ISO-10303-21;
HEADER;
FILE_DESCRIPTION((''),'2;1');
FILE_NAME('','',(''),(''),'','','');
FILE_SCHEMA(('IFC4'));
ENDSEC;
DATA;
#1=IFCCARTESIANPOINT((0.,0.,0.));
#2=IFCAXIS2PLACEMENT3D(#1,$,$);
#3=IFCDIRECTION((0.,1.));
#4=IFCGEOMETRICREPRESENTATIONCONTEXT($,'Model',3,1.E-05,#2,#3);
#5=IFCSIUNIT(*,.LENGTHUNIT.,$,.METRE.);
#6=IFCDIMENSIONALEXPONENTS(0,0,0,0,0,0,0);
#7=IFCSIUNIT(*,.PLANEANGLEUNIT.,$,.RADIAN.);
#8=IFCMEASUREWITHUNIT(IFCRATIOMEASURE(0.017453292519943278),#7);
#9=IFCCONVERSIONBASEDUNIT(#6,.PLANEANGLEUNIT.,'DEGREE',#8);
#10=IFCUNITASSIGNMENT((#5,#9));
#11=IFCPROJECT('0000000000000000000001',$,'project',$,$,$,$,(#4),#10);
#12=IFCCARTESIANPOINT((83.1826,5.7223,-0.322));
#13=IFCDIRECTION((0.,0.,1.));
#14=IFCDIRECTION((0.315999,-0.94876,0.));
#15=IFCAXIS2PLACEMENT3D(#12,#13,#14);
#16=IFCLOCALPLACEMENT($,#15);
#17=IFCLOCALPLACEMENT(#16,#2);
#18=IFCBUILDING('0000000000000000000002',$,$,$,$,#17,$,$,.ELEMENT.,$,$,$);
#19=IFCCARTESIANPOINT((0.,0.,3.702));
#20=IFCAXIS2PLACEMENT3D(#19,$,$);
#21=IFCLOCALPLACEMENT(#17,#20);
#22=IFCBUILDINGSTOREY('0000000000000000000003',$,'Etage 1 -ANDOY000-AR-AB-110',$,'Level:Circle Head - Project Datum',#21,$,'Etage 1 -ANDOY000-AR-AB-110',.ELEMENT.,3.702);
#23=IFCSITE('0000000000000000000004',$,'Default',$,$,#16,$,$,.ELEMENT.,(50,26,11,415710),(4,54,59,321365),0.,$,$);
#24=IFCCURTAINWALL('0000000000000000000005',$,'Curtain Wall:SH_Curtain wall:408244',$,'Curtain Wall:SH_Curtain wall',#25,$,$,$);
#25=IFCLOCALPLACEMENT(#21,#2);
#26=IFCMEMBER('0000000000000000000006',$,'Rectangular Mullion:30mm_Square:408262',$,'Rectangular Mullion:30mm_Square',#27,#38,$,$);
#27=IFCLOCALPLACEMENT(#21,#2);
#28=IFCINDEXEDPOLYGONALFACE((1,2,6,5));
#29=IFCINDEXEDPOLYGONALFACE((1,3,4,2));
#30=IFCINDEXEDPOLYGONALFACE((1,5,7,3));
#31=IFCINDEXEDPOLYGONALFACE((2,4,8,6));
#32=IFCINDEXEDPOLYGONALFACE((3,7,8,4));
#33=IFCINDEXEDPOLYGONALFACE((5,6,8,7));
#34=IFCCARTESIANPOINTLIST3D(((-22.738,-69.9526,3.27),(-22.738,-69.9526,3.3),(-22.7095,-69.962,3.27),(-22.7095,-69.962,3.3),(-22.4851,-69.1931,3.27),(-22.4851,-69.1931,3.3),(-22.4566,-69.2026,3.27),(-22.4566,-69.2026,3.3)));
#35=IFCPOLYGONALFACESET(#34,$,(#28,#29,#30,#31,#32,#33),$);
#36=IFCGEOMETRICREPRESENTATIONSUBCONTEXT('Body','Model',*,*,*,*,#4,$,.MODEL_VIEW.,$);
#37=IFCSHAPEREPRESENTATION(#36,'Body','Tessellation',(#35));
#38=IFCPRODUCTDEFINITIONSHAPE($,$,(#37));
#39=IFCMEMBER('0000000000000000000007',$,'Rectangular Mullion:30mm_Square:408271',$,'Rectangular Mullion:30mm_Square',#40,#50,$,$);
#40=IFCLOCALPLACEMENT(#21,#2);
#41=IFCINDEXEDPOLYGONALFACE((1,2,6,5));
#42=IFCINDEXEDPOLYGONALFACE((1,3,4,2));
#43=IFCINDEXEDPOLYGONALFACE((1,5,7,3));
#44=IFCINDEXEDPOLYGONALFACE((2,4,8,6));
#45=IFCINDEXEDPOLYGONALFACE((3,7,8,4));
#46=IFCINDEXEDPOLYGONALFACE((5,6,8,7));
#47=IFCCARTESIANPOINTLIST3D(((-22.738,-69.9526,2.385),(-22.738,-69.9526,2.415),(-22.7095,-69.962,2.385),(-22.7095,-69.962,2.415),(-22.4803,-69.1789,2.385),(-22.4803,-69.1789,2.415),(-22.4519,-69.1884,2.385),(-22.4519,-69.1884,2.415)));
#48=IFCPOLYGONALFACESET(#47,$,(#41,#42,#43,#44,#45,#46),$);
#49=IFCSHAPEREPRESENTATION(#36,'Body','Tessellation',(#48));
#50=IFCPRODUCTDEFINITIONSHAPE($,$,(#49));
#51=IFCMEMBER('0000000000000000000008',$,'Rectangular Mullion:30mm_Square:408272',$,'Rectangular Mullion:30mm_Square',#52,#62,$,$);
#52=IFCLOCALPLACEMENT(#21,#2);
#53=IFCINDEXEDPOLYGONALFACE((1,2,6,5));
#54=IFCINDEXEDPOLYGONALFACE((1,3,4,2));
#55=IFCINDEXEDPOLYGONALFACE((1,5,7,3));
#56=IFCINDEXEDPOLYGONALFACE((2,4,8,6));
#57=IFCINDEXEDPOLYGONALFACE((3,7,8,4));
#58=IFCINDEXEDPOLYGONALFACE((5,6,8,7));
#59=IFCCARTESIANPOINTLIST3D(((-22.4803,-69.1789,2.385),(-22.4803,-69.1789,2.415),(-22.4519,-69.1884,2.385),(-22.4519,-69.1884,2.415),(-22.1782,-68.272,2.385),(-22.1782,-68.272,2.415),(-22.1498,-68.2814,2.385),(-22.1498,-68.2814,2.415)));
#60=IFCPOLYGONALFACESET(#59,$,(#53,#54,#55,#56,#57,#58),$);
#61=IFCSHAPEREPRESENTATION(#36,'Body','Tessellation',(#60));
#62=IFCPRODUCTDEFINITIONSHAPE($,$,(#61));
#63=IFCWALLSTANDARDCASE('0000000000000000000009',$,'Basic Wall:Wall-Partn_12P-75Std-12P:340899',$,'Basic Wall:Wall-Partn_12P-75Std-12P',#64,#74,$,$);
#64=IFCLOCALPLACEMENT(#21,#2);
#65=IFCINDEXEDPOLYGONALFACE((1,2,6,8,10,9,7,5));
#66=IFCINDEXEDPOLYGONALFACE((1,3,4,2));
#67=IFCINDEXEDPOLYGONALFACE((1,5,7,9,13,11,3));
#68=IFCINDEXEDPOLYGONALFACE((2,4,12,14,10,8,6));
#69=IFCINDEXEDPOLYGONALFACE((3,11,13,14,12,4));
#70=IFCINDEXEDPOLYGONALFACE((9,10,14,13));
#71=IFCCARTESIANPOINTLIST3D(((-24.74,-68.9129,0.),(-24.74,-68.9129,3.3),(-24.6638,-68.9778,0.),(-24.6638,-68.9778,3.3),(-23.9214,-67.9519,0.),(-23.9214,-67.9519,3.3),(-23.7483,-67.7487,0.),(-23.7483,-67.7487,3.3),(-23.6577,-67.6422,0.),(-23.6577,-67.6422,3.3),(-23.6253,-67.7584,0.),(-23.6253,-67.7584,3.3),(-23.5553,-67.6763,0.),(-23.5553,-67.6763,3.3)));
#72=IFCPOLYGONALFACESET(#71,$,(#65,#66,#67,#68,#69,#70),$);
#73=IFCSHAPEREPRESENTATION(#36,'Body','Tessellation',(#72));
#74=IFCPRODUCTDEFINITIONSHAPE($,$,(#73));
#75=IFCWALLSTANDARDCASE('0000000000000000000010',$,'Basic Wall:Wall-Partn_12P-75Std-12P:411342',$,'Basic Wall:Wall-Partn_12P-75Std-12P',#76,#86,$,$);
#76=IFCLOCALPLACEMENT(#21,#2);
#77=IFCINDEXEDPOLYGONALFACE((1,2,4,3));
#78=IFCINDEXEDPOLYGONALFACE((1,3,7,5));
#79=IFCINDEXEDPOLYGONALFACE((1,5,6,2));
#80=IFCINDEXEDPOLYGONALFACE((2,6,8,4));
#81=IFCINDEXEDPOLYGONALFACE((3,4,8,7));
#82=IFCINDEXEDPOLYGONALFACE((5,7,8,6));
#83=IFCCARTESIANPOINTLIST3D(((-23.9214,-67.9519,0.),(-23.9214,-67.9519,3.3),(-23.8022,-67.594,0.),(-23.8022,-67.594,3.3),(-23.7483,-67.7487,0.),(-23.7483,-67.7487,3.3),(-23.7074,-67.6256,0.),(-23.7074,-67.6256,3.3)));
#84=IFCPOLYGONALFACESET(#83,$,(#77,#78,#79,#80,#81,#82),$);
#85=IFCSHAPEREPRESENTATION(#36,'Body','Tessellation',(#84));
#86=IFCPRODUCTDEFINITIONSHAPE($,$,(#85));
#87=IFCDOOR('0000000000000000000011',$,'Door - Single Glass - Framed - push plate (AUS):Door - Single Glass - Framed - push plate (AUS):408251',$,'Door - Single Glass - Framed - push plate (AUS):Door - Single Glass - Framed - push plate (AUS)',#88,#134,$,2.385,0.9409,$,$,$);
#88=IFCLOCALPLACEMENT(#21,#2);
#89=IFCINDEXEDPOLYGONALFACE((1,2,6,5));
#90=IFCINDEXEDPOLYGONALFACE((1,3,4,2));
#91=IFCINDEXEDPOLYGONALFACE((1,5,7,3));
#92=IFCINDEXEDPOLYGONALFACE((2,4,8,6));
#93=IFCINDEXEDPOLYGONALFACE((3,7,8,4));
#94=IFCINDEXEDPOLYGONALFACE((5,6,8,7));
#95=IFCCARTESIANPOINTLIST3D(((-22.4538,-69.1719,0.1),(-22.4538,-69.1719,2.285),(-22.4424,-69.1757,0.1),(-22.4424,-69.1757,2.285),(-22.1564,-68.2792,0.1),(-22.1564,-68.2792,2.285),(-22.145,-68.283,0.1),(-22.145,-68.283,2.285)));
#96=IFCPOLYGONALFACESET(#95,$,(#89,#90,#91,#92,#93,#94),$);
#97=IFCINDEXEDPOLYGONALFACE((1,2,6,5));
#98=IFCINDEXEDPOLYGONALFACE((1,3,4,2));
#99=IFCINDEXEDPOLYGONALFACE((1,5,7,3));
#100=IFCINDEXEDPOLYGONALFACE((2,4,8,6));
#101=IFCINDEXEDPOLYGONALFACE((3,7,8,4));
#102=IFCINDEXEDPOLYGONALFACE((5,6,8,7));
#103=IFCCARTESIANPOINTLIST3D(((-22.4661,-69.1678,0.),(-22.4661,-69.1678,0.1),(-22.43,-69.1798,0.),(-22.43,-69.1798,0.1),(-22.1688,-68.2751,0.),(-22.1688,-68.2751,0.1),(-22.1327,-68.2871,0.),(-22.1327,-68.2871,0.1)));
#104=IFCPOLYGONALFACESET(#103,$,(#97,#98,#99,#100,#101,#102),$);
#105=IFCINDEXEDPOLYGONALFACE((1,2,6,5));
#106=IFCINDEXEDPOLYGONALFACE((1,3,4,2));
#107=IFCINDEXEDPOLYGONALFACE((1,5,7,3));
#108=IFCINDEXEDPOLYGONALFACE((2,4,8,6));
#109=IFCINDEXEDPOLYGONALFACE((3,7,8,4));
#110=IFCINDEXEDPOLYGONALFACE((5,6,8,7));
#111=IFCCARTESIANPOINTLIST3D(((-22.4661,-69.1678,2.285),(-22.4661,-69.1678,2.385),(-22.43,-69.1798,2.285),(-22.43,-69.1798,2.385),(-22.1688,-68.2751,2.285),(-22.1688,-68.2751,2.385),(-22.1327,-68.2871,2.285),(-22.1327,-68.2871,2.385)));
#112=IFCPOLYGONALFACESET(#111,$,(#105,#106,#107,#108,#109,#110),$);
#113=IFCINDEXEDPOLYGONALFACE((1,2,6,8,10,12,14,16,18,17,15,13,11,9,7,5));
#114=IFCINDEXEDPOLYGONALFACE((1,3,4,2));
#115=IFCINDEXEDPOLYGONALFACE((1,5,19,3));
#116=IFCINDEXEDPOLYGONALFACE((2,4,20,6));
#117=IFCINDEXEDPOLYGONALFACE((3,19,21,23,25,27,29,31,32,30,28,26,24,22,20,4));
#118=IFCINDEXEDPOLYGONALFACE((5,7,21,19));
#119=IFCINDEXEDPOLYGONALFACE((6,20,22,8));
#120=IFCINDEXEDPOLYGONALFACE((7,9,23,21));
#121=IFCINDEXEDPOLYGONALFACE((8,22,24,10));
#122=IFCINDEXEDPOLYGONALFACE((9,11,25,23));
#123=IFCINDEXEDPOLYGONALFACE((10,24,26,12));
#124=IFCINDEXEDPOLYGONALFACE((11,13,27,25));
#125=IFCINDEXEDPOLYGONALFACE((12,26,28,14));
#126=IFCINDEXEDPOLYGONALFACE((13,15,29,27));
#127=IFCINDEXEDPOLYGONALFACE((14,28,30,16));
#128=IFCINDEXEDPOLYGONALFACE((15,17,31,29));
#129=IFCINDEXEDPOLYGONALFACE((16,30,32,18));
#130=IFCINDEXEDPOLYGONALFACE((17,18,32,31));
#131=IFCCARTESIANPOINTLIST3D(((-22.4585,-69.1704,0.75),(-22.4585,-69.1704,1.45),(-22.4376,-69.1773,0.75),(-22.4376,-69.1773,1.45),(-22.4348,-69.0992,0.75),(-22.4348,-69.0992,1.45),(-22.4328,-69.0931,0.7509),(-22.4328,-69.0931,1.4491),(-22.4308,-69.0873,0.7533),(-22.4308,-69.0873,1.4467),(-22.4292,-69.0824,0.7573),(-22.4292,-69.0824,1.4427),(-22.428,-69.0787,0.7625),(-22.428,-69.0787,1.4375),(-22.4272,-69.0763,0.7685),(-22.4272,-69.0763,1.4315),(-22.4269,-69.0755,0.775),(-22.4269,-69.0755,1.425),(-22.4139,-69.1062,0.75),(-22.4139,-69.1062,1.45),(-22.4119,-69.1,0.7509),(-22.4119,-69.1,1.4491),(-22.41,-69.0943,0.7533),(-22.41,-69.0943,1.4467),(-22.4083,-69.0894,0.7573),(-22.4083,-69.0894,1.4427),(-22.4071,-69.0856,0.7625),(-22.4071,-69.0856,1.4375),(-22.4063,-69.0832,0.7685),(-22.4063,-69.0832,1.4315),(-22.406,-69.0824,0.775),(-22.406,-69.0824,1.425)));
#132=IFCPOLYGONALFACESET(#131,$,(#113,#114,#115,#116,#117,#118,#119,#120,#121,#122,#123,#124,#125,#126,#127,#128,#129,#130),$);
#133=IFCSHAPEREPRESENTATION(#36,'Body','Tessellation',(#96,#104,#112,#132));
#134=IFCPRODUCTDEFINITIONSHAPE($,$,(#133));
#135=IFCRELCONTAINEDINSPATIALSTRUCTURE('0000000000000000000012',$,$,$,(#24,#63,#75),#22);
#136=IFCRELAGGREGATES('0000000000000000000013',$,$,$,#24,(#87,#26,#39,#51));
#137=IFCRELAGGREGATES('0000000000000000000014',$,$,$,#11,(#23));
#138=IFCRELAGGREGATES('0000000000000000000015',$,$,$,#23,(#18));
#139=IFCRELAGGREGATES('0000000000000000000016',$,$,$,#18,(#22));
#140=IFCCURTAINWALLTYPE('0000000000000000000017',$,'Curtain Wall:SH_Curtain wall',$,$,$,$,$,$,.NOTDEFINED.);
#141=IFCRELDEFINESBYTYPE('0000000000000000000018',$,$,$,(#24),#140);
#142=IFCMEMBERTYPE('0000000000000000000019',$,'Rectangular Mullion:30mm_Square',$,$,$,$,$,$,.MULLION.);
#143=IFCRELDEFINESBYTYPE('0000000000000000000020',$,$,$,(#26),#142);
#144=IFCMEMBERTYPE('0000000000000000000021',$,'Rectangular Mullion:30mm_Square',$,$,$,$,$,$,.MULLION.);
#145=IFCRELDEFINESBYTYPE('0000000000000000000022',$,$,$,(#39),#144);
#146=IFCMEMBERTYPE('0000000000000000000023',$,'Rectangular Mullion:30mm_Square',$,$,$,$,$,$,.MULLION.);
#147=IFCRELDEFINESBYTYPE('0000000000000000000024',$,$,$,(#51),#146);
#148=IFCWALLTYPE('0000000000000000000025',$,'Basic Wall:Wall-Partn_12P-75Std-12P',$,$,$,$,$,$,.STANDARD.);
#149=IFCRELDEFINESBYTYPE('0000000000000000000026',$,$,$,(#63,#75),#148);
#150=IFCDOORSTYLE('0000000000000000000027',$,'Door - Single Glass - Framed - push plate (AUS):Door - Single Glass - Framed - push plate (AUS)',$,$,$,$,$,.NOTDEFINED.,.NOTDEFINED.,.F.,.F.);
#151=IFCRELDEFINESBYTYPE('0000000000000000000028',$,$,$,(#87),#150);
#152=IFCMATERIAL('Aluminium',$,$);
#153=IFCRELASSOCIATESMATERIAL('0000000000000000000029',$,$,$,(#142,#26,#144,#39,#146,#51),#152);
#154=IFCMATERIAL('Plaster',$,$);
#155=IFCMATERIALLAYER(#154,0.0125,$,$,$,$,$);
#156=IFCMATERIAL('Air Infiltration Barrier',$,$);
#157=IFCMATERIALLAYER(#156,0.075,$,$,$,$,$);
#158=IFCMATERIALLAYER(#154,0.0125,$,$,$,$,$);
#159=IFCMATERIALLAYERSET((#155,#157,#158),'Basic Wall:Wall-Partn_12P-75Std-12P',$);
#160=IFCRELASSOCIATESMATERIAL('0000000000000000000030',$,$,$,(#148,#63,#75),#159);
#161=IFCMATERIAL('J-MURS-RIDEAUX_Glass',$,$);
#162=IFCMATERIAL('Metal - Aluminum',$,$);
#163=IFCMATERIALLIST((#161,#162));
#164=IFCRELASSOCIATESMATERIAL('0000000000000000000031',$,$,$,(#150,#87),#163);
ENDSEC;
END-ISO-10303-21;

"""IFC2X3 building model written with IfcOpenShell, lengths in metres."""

from ifc_helpers import new_model, entity, si_unit, converted_unit, direction, frame, frame_2d, origin, origin_2d_with_axis, place, context, subcontext, project, spatial, polyline, circle_curve, parameter, trimmed, segment, composite_curve, rectangle, outline, extrude, source, transform, mapped, material, material_list, layer, layer_set, layer_usage, type_object, type_shapes, element, aggregate, save


model = new_model("IFC2X3")

# Units and contexts
model_context = context("Model", 3, precision=1e-05, world=origin(), true_north=direction((0.0, 1.0)))
body_context = subcontext(model_context, "Body", "Model", "MODEL_VIEW")
ifc_project = project(units=[si_unit("LENGTHUNIT", "METRE"), converted_unit("PLANEANGLEUNIT", "DEGREE", entity("IfcRatioMeasure", 0.017453292519943278), si_unit("PLANEANGLEUNIT", "RADIAN"), dimensions=[0, 0, 0, 0, 0, 0, 0])], contexts=[model_context])

# Site, building, storey
site_placement = place(None, frame((83.1826, 5.7223, -0.322), z_axis=(0.0, 0.0, 1.0), x_axis=(0.315999, -0.94876, 0.0)))
site = spatial("IfcSite", under=ifc_project, at=site_placement, Name="Default", CompositionType="ELEMENT", RefLatitude=(50, 26, 11, 415710), RefLongitude=(4, 54, 59, 321365), RefElevation=0.0)
building_placement = place(site_placement, origin())
building = spatial("IfcBuilding", under=site, at=building_placement, CompositionType="ELEMENT")
storey_placement = place(building_placement, frame((0.0, 0.0, 3.702)))
storey = spatial("IfcBuildingStorey", under=building, at=storey_placement, Name="Etage 1 -ANDOY000-AR-AB-110", ObjectType="Level:Circle Head - Project Datum", LongName="Etage 1 -ANDOY000-AR-AB-110", CompositionType="ELEMENT", Elevation=3.702)

# Shared definitions
curtain_wall_type_1 = type_object("IfcCurtainWallType", Name="Curtain Wall:SH_Curtain wall", PredefinedType="NOTDEFINED")
ifc_material_1 = material(Name="Aluminium")

# Curtain wall
curtain_wall_1_placement = place(storey_placement, frame((0.0, 0.0, -3.702)))
curtain_wall_1 = element("IfcCurtainWall", 1, at=curtain_wall_1_placement, inside=storey, type_object=curtain_wall_type_1, Name="Curtain Wall:SH_Curtain wall:408244", ObjectType="Curtain Wall:SH_Curtain wall")

# Members
member_type_1 = type_object("IfcMemberType", Name="Rectangular Mullion:30mm_Square", PredefinedType="MULLION", material=ifc_material_1)
shared_shape_1 = source(origin(), body_context, "Body", "SweptSolid", [
    extrude(rectangle(XDim=0.03, YDim=0.03, at=frame_2d((0.0, 0.0), x_axis=(1.0, 0.0))), frame((-0.015, 0.0, -0.8005), z_axis=(0.0, 0.0, 1.0), x_axis=(0.0, -1.0, 0.0)), (0.0, 0.0, 1.0), 0.8005),
])
type_shapes(member_type_1, [shared_shape_1])
member_1_placement = place(curtain_wall_1_placement, frame((-22.4708, -69.1979, 7.002), z_axis=(0.316, 0.948759, 0.0), x_axis=(0.0, 0.0, 1.0)))
member_1 = element("IfcMember", 2, at=member_1_placement, type_object=member_type_1, material=ifc_material_1, Name="Rectangular Mullion:30mm_Square:408262", ObjectType="Rectangular Mullion:30mm_Square", context=body_context, shape_type="MappedRepresentation", body=[
    mapped(shared_shape_1, transform((0.0, 0.0, 0.0), scale=1.0)),
])
member_type_2 = type_object("IfcMemberType", Name="Rectangular Mullion:30mm_Square", PredefinedType="MULLION", material=ifc_material_1)
shared_shape_2 = source(origin(), body_context, "Body", "SweptSolid", [
    extrude(rectangle(XDim=0.03, YDim=0.03, at=frame_2d((0.0, 0.0), x_axis=(1.0, 0.0))), frame((0.0, 0.0, -0.8155), z_axis=(0.0, 0.0, 1.0), x_axis=(0.0, -1.0, 0.0)), (0.0, 0.0, 1.0), 0.8155),
])
type_shapes(member_type_2, [shared_shape_2])
member_2_placement = place(curtain_wall_1_placement, frame((-22.4661, -69.1836, 6.102), z_axis=(0.316, 0.948759, 0.0), x_axis=(0.0, 0.0, 1.0)))
member_2 = element("IfcMember", 3, at=member_2_placement, type_object=member_type_2, material=ifc_material_1, Name="Rectangular Mullion:30mm_Square:408271", ObjectType="Rectangular Mullion:30mm_Square", context=body_context, shape_type="MappedRepresentation", body=[
    mapped(shared_shape_2, transform((0.0, 0.0, 0.0), scale=1.0)),
])
member_type_3 = type_object("IfcMemberType", Name="Rectangular Mullion:30mm_Square", PredefinedType="MULLION", material=ifc_material_1)
shared_shape_3 = source(origin(), body_context, "Body", "SweptSolid", [
    extrude(rectangle(XDim=0.03, YDim=0.03, at=frame_2d((0.0, 0.0), x_axis=(1.0, 0.0))), frame((0.0, 0.0, -0.9559), z_axis=(0.0, 0.0, 1.0), x_axis=(0.0, -1.0, 0.0)), (0.0, 0.0, 1.0), 0.9559),
])
type_shapes(member_type_3, [shared_shape_3])
member_3_placement = place(curtain_wall_1_placement, frame((-22.164, -68.2767, 6.102), z_axis=(0.316, 0.948759, 0.0), x_axis=(0.0, 0.0, 1.0)))
member_3 = element("IfcMember", 4, at=member_3_placement, type_object=member_type_3, material=ifc_material_1, Name="Rectangular Mullion:30mm_Square:408272", ObjectType="Rectangular Mullion:30mm_Square", context=body_context, shape_type="MappedRepresentation", body=[
    mapped(shared_shape_3, transform((0.0, 0.0, 0.0), scale=1.0)),
])

# Shared definitions
ifc_material_2 = material(Name="J-MURS-RIDEAUX_Glass")

# Walls
ifc_material_3 = material(Name="Plaster")
ifc_layer_1 = layer(ifc_material_3, 0.0125)
ifc_material_4 = material(Name="Air Infiltration Barrier")
ifc_layer_2 = layer(ifc_material_4, 0.075)
ifc_layer_3 = layer(ifc_material_3, 0.0125)
ifc_layer_set = layer_set([ifc_layer_1, ifc_layer_2, ifc_layer_3], Name="Basic Wall:Wall-Partn_12P-75Std-12P")
ifc_layer_usage = layer_usage(ifc_layer_set, "AXIS2", "NEGATIVE", 0.05)
wall_type = type_object("IfcWallType", Name="Basic Wall:Wall-Partn_12P-75Std-12P", PredefinedType="STANDARD", material=ifc_layer_set)
wall_1_placement = place(storey_placement, frame((-23.5934, -67.6439, 0.0), z_axis=(0.0, 0.0, 1.0), x_axis=(-0.648402, -0.761298, 0.0)))
element("IfcWallStandardCase", 5, at=wall_1_placement, inside=storey, type_object=wall_type, material=ifc_layer_usage, Name="Basic Wall:Wall-Partn_12P-75Std-12P:340899", ObjectType="Basic Wall:Wall-Partn_12P-75Std-12P", context=body_context, shape_type="SweptSolid", body=[
    extrude(outline(polyline([(1.7096, -0.05), (1.7096, 0.05), (0.1079, 0.05), (0.0, 0.05), (0.0404, -0.05), (0.1803, -0.05), (0.4472, -0.05), (1.7096, -0.05)])), origin(), (0.0, 0.0, 1.0), 3.3),
])
wall_2_placement = place(storey_placement, frame((-23.7548, -67.6098, 0.0), z_axis=(0.0, 0.0, 1.0), x_axis=(-0.316, -0.948759, 0.0)))
element("IfcWallStandardCase", 6, at=wall_2_placement, inside=storey, type_object=wall_type, material=ifc_layer_usage, Name="Basic Wall:Wall-Partn_12P-75Std-12P:411342", ObjectType="Basic Wall:Wall-Partn_12P-75Std-12P", context=body_context, shape_type="SweptSolid", body=[
    extrude(outline(polyline([(0.3772, -0.05), (0.1297, 0.05), (0.0, 0.05), (0.0, -0.05), (0.3772, -0.05)])), origin(), (0.0, 0.0, 1.0), 3.3),
])

# Door
ifc_material_5 = material(Name="Metal - Aluminum")
ifc_material_list = material_list([ifc_material_2, ifc_material_5])
door_style_1 = type_object("IfcDoorStyle", Name="Door - Single Glass - Framed - push plate (AUS):Door - Single Glass - Framed - push plate (AUS)", ConstructionType="NOTDEFINED", OperationType="NOTDEFINED", ParameterTakesPrecedence=False, Sizeable=False, material=ifc_material_list)
shared_shape_4 = source(origin(), body_context, "Body", "SweptSolid", [
    extrude(rectangle(XDim=0.012, YDim=0.9409, at=frame_2d((0.0, 0.0), x_axis=(1.0, 0.0))), frame((0.0, 0.014, 0.1), z_axis=(0.0, 0.0, 1.0), x_axis=(0.0, -1.0, 0.0)), (0.0, 0.0, 1.0), 2.185),
    extrude(rectangle(XDim=0.9409, YDim=0.038, at=origin_2d_with_axis()), frame((0.0, 0.014, 0.0)), (0.0, 0.0, 1.0), 0.1),
    extrude(rectangle(XDim=0.9409, YDim=0.038, at=origin_2d_with_axis()), frame((0.0, 0.014, 2.285)), (0.0, 0.0, 1.0), 0.1),
    extrude(outline(composite_curve([segment(trimmed(circle_curve(frame_2d((0.0167, -0.325), x_axis=(1.0, 0.0)), 0.025), [parameter(270.0)], [parameter(0.0)], True, "PARAMETER"), True, "CONTINUOUS"), segment(polyline([(0.0417, -0.325), (0.0417, 0.325)]), True, "CONTINUOUS"), segment(trimmed(circle_curve(frame_2d((0.0167, 0.325), x_axis=(1.0, 0.0)), 0.025), [parameter(0.0)], [parameter(90.0)], True, "PARAMETER"), True, "CONTINUOUS"), segment(polyline([(0.0167, 0.35), (-0.0583, 0.35)]), True, "CONTINUOUS"), segment(polyline([(-0.0583, 0.35), (-0.0583, -0.35)]), True, "CONTINUOUS"), segment(polyline([(-0.0583, -0.35), (0.0167, -0.35)]), True, "CONTINUOUS")], self_intersect=False)), frame((0.4121, 0.025, 1.1), z_axis=(0.0, -1.0, 0.0), x_axis=(-1.0, 0.0, 0.0)), (0.0, 0.0, 1.0), 0.022),
])
type_shapes(door_style_1, [shared_shape_4])
door_1_placement = place(curtain_wall_1_placement, frame((-22.3127, -68.7231, 3.702), z_axis=(0.0, 0.0, 1.0), x_axis=(-0.316, -0.948759, 0.0)))
door_1 = element("IfcDoor", 7, at=door_1_placement, type_object=door_style_1, material=ifc_material_list, Name="Door - Single Glass - Framed - push plate (AUS):Door - Single Glass - Framed - push plate (AUS):408251", ObjectType="Door - Single Glass - Framed - push plate (AUS):Door - Single Glass - Framed - push plate (AUS)", OverallHeight=2.385, OverallWidth=0.9409, context=body_context, shape_type="MappedRepresentation", body=[
    mapped(shared_shape_4, transform((0.0, 0.0, 0.0), scale=1.0)),
])
aggregate(curtain_wall_1, [door_1, member_1, member_2, member_3])

save(model, "model.ifc")
